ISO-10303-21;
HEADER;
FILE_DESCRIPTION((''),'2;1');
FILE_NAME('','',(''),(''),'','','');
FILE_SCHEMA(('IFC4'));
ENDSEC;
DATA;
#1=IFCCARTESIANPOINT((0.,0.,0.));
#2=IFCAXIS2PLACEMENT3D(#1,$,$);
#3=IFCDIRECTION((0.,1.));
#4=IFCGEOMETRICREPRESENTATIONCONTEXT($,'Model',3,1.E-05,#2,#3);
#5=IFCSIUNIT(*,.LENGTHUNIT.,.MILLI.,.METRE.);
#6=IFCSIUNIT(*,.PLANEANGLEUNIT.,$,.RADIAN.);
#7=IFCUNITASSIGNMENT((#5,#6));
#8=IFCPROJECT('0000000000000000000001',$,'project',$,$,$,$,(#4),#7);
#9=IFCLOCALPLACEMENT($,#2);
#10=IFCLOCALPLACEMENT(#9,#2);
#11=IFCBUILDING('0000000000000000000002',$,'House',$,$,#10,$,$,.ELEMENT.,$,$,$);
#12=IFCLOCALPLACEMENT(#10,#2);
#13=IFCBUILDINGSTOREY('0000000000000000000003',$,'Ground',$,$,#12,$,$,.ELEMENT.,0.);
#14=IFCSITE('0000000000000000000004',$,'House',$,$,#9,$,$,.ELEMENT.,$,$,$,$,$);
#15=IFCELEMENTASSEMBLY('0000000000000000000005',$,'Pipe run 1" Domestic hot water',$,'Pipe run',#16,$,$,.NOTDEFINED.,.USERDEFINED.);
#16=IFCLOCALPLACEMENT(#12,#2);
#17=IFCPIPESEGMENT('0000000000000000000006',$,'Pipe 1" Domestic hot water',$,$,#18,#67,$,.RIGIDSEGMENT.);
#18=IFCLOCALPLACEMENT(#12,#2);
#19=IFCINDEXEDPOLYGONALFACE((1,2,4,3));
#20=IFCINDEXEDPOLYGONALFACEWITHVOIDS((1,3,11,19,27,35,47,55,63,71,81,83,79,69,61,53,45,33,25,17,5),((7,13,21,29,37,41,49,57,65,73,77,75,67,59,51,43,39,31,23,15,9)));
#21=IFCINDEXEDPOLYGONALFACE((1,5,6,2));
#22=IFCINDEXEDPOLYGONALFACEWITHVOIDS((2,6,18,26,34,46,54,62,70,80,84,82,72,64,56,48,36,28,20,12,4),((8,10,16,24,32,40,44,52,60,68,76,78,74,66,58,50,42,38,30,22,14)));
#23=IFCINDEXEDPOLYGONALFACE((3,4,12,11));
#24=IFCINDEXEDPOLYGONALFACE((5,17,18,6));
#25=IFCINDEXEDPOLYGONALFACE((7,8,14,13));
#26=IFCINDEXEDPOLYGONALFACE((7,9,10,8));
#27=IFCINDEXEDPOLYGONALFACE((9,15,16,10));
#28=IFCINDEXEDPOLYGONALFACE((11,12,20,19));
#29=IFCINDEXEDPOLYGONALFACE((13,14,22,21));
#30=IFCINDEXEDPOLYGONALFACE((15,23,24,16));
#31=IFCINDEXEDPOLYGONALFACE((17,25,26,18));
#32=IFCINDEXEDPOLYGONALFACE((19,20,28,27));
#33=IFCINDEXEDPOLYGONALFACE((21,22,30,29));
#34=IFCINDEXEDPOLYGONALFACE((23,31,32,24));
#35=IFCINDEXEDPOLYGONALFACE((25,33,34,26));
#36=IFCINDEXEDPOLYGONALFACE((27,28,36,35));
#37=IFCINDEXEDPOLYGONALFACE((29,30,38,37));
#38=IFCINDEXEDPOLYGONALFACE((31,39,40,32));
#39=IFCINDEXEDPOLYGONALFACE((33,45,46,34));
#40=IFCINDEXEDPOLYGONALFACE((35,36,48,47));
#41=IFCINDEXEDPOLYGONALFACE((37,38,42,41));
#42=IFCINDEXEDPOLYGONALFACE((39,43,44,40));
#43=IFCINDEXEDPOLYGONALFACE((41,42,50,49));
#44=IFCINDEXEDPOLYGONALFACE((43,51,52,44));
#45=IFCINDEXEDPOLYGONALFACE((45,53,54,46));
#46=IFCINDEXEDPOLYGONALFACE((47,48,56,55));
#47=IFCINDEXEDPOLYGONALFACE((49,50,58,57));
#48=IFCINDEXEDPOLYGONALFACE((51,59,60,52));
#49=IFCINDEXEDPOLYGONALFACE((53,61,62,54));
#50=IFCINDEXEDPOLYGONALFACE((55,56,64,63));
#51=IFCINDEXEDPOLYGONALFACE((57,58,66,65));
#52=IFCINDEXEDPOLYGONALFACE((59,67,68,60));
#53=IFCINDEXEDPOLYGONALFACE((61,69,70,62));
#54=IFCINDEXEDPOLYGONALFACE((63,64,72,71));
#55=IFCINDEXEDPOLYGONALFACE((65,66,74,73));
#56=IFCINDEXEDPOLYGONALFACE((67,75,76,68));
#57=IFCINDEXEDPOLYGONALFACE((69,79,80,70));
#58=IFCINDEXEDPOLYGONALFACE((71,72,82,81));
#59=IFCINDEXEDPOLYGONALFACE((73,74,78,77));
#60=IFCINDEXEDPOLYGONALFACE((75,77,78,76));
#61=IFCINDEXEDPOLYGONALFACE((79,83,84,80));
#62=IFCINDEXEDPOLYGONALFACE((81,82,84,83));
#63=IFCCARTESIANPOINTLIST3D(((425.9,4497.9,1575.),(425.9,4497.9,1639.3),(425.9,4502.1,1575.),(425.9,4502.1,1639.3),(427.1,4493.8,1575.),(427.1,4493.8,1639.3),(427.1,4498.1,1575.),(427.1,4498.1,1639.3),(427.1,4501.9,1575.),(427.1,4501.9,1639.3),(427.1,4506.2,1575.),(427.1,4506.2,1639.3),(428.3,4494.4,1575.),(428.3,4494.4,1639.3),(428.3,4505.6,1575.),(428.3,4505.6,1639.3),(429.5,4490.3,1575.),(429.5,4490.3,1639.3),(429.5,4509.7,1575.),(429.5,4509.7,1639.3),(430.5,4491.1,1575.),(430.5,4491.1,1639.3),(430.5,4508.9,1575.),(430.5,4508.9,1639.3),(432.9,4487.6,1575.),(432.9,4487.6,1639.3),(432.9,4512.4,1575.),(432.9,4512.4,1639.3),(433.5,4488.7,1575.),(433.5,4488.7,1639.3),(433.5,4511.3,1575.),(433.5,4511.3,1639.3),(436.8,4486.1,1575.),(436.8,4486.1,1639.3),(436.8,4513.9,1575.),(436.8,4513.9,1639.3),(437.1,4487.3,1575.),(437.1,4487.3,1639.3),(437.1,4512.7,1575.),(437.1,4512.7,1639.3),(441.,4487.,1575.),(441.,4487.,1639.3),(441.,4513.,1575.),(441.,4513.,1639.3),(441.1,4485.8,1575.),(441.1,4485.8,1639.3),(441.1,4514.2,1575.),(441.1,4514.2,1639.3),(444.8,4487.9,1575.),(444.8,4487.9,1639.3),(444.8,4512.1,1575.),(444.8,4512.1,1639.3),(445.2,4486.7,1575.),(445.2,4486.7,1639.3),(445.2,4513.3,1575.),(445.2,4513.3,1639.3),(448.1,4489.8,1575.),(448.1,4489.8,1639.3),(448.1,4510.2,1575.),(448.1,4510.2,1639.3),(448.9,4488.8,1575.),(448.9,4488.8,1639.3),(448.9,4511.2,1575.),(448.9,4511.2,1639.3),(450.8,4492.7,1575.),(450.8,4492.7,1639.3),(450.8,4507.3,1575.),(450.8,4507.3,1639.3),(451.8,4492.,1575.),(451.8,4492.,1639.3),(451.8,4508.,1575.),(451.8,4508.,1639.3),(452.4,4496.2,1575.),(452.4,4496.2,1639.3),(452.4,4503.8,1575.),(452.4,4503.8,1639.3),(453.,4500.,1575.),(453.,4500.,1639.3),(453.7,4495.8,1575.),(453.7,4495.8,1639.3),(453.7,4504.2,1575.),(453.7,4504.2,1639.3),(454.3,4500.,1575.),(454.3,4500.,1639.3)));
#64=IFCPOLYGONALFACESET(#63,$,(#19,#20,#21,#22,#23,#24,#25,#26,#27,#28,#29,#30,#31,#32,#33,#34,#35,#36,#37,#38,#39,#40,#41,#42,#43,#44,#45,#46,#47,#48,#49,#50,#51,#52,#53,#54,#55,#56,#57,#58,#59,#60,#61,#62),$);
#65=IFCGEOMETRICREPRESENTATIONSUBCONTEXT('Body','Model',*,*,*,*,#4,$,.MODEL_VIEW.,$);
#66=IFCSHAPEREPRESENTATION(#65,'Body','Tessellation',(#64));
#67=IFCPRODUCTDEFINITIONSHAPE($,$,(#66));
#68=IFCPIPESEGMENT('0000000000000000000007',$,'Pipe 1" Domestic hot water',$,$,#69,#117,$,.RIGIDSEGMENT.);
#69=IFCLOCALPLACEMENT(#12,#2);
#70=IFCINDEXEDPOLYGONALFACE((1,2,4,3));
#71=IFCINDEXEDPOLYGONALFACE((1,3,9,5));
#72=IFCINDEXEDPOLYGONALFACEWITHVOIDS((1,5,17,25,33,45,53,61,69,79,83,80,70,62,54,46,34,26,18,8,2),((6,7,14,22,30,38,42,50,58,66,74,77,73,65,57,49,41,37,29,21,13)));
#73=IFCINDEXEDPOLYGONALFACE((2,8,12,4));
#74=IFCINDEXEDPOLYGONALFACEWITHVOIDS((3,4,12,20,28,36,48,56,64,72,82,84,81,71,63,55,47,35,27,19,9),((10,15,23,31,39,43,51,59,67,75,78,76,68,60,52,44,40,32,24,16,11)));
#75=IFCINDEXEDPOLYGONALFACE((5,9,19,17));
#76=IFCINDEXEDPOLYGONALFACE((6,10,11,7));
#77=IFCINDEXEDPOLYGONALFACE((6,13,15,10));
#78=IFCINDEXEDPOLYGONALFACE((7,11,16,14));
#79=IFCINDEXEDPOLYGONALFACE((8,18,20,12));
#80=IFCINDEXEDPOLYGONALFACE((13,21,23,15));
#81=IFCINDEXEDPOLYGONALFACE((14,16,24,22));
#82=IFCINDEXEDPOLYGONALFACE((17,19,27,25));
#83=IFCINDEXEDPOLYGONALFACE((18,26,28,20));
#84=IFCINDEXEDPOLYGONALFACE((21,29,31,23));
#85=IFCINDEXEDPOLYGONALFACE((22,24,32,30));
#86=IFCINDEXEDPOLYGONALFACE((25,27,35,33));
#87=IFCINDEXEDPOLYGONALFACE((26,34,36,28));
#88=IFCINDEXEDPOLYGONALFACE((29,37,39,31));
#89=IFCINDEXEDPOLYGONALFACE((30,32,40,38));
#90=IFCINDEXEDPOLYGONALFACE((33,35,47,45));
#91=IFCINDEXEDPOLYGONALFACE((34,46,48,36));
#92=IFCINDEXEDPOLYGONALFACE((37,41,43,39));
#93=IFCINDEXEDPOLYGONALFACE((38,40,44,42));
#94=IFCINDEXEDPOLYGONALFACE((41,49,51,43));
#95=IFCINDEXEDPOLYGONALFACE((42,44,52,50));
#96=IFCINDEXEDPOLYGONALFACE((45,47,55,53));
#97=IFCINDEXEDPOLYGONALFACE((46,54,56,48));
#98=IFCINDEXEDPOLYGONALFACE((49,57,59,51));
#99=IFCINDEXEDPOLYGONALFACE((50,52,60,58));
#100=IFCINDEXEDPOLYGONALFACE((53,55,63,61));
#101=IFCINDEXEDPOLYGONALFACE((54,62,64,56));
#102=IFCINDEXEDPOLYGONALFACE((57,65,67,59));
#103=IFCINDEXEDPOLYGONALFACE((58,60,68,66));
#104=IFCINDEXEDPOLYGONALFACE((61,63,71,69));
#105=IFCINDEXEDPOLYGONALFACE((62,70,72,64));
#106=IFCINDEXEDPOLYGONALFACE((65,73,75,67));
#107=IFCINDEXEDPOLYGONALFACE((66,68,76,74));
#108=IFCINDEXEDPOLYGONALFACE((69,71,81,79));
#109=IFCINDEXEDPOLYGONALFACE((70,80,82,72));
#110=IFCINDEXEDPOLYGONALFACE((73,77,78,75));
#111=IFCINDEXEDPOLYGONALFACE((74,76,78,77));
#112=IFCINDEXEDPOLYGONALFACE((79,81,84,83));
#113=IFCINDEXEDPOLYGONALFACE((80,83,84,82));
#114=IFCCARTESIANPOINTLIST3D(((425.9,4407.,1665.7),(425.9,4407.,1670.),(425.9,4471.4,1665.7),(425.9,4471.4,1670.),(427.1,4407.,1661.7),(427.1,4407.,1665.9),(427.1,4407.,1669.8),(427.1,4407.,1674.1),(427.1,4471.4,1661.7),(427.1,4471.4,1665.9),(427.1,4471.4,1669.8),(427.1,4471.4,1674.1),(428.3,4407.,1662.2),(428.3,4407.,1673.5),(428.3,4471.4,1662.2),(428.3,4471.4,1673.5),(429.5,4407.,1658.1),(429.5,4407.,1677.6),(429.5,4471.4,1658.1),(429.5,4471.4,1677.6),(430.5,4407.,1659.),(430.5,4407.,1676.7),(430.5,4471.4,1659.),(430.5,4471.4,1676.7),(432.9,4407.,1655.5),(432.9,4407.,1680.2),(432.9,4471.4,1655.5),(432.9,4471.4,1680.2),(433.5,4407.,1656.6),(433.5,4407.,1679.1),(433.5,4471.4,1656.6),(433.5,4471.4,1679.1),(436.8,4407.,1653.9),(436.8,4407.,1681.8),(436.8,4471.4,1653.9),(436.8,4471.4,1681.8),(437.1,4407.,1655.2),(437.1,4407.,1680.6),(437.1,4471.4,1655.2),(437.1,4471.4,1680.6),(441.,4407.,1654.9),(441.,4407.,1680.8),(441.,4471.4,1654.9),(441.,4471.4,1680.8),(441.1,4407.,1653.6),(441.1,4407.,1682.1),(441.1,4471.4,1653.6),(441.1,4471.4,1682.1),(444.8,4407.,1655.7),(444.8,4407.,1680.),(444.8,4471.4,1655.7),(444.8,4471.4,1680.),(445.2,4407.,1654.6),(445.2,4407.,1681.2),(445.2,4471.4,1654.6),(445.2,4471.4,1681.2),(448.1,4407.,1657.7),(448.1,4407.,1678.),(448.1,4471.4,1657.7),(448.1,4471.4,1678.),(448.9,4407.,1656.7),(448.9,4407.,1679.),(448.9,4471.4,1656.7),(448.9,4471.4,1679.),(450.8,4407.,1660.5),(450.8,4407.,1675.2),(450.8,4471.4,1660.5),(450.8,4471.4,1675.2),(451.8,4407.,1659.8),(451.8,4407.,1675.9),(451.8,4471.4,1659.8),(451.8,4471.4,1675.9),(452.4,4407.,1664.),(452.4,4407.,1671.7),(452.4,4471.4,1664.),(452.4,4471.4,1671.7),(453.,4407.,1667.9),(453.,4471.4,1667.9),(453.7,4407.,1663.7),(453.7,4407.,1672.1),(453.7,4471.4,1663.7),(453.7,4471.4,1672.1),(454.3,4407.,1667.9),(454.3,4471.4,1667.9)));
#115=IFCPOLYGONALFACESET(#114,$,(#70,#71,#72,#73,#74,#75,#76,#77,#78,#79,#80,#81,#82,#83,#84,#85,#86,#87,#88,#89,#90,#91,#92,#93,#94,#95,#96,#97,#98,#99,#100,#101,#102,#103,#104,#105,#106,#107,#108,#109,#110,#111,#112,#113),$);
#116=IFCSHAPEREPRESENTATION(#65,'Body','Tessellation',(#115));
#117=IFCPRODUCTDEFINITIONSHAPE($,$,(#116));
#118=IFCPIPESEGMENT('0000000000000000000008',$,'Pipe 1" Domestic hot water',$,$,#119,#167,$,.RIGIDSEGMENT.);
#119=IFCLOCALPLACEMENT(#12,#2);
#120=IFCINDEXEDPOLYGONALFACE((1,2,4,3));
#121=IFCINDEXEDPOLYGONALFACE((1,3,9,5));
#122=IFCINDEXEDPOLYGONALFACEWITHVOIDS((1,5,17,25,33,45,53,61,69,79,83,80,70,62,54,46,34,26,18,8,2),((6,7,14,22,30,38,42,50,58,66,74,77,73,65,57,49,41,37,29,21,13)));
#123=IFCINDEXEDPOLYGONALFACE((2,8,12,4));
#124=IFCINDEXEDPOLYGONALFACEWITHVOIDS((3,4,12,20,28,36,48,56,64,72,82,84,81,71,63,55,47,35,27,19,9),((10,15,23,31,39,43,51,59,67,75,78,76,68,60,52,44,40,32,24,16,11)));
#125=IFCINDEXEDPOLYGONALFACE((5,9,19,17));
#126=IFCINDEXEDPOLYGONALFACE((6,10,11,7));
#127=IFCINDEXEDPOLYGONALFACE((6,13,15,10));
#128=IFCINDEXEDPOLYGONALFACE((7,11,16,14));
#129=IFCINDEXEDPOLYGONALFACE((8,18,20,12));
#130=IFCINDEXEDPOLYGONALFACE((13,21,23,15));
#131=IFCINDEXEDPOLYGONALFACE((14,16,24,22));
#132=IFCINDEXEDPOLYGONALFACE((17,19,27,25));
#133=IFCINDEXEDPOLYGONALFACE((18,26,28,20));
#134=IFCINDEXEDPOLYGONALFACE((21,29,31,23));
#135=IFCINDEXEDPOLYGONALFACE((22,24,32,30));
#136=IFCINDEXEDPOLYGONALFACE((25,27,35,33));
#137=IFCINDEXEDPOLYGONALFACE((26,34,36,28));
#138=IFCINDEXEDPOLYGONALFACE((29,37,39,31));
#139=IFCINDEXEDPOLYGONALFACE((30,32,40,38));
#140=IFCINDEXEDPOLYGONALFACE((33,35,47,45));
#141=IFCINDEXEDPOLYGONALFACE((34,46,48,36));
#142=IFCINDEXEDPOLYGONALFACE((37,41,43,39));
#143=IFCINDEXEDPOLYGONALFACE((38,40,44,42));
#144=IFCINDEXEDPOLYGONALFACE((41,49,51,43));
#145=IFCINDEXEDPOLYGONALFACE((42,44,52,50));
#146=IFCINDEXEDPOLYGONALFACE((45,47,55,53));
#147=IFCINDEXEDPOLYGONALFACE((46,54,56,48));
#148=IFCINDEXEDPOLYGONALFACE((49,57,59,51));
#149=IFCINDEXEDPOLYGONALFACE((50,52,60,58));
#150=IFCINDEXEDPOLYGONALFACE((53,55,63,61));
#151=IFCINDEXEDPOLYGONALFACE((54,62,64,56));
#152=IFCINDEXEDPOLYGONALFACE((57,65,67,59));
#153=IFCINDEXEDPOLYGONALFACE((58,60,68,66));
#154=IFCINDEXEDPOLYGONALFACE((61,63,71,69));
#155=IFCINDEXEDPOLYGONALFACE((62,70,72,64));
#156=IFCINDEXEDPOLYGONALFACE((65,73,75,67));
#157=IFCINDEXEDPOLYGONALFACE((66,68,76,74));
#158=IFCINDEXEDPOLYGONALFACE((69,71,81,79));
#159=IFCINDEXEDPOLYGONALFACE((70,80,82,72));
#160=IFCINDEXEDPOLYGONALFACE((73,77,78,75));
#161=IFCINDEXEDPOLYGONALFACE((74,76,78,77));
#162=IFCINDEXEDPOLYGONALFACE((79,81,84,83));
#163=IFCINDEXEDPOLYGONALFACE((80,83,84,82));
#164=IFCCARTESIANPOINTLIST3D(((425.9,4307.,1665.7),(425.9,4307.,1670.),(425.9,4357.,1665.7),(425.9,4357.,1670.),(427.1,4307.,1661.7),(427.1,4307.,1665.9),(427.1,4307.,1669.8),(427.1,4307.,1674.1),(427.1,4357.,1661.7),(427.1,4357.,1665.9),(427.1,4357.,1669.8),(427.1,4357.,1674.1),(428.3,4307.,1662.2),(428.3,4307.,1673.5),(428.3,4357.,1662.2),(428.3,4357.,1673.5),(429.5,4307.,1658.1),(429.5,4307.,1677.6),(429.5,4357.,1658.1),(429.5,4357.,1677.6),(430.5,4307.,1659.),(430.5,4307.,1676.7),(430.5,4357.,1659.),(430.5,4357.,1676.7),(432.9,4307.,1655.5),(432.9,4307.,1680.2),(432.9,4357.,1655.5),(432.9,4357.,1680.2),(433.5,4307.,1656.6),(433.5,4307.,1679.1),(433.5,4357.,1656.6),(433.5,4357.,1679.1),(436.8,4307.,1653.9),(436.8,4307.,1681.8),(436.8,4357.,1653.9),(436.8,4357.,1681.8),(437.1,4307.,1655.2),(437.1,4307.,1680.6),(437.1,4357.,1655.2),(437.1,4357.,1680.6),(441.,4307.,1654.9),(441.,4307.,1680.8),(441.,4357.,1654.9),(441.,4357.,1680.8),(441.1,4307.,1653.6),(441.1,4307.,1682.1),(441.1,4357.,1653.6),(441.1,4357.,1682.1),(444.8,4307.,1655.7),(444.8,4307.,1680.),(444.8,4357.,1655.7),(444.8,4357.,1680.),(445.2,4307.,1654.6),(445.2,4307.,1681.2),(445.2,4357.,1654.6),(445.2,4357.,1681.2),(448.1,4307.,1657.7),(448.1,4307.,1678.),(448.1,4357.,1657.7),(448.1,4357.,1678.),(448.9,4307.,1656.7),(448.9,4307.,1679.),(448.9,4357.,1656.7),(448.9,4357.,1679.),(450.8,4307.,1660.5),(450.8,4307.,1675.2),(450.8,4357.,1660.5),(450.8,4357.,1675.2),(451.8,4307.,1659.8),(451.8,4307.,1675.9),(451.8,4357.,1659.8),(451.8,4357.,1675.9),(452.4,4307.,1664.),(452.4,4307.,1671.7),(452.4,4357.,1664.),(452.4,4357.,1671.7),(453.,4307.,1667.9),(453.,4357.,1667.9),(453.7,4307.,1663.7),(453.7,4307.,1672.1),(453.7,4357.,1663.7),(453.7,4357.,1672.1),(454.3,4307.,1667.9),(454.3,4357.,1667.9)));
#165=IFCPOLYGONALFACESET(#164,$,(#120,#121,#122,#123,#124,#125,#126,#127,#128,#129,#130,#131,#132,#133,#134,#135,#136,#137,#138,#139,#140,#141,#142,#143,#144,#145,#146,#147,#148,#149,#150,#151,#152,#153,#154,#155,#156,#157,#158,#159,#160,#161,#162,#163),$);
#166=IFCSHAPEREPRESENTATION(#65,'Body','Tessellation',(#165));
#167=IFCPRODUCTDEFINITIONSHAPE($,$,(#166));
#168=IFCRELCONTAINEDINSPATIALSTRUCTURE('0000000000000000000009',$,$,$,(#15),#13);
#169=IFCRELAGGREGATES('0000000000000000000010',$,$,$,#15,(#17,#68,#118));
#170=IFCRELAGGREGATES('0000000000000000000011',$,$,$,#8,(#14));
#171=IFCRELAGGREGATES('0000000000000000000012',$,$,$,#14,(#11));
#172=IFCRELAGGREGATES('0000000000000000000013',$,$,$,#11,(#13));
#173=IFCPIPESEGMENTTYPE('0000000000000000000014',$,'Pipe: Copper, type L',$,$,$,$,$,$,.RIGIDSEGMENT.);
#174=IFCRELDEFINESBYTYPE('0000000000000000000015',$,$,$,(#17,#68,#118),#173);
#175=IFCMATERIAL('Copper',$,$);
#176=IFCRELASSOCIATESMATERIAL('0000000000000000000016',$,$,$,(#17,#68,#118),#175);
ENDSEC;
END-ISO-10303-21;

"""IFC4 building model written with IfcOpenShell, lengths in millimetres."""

from ifc_helpers import new_model, si_unit, direction, frame, origin, origin_with_axes, origin_2d, place, context, subcontext, project, spatial, hollow_circle, extrude, material, type_object, element, aggregate, save


model = new_model("IFC4")

# Units and contexts
model_context = context("Model", 3, precision=1e-05, world=origin(), true_north=direction((0.0, 1.0)))
body_context = subcontext(model_context, "Body", "Model", "MODEL_VIEW")
ifc_project = project(units=[si_unit("LENGTHUNIT", "METRE", prefix="MILLI"), si_unit("PLANEANGLEUNIT", "RADIAN")], contexts=[model_context])

# Site, building, storey
site_placement = place(None, origin())
site = spatial("IfcSite", under=ifc_project, at=site_placement, Name="House", CompositionType="ELEMENT")
building_placement = place(site_placement, origin())
building = spatial("IfcBuilding", under=site, at=building_placement, Name="House", CompositionType="ELEMENT")
storey_placement = place(building_placement, origin())
storey = spatial("IfcBuildingStorey", under=building, at=storey_placement, Name="Ground", CompositionType="ELEMENT", Elevation=0.0)

# Element assembly, pipe segments
assembly_1_placement = place(storey_placement, origin_with_axes())
assembly_1 = element("IfcElementAssembly", 1, at=assembly_1_placement, inside=storey, Name="Pipe run 1\" Domestic hot water", ObjectType="Pipe run", AssemblyPlace="NOTDEFINED", PredefinedType="USERDEFINED")
ifc_material = material(Name="Copper")
pipe_segment_type = type_object("IfcPipeSegmentType", Name="Pipe: Copper, type L", PredefinedType="RIGIDSEGMENT")
pipe_segment_1_placement = place(storey_placement, origin_with_axes())
pipe_segment_1 = element("IfcPipeSegment", 2, at=pipe_segment_1_placement, type_object=pipe_segment_type, material=ifc_material, Name="Pipe 1\" Domestic hot water", PredefinedType="RIGIDSEGMENT", context=body_context, shape_type="SweptSolid", body=[
    extrude(hollow_circle(Radius=14.3, WallThickness=1.3, at=origin_2d()), frame((440.0, 4500.0, 1575.0), z_axis=(0.0, 0.0, 1.0), x_axis=(1.0, 0.0, 0.0)), (0.0, 0.0, 1.0), 64.3),
])
pipe_segment_2_placement = place(storey_placement, origin_with_axes())
pipe_segment_2 = element("IfcPipeSegment", 3, at=pipe_segment_2_placement, type_object=pipe_segment_type, material=ifc_material, Name="Pipe 1\" Domestic hot water", PredefinedType="RIGIDSEGMENT", context=body_context, shape_type="SweptSolid", body=[
    extrude(hollow_circle(Radius=14.3, WallThickness=1.3, at=origin_2d()), frame((440.0, 4471.4, 1667.9), z_axis=(0.0, -1.0, 0.0), x_axis=(1.0, 0.0, 0.0)), (0.0, 0.0, 1.0), 64.4),
])
pipe_segment_3_placement = place(storey_placement, origin_with_axes())
pipe_segment_3 = element("IfcPipeSegment", 4, at=pipe_segment_3_placement, type_object=pipe_segment_type, material=ifc_material, Name="Pipe 1\" Domestic hot water", PredefinedType="RIGIDSEGMENT", context=body_context, shape_type="SweptSolid", body=[
    extrude(hollow_circle(Radius=14.3, WallThickness=1.3, at=origin_2d()), frame((440.0, 4357.0, 1667.9), z_axis=(0.0, -1.0, 0.0), x_axis=(1.0, 0.0, 0.0)), (0.0, 0.0, 1.0), 50.0),
])

aggregate(assembly_1, [pipe_segment_1, pipe_segment_2, pipe_segment_3])

save(model, "model.ifc")
